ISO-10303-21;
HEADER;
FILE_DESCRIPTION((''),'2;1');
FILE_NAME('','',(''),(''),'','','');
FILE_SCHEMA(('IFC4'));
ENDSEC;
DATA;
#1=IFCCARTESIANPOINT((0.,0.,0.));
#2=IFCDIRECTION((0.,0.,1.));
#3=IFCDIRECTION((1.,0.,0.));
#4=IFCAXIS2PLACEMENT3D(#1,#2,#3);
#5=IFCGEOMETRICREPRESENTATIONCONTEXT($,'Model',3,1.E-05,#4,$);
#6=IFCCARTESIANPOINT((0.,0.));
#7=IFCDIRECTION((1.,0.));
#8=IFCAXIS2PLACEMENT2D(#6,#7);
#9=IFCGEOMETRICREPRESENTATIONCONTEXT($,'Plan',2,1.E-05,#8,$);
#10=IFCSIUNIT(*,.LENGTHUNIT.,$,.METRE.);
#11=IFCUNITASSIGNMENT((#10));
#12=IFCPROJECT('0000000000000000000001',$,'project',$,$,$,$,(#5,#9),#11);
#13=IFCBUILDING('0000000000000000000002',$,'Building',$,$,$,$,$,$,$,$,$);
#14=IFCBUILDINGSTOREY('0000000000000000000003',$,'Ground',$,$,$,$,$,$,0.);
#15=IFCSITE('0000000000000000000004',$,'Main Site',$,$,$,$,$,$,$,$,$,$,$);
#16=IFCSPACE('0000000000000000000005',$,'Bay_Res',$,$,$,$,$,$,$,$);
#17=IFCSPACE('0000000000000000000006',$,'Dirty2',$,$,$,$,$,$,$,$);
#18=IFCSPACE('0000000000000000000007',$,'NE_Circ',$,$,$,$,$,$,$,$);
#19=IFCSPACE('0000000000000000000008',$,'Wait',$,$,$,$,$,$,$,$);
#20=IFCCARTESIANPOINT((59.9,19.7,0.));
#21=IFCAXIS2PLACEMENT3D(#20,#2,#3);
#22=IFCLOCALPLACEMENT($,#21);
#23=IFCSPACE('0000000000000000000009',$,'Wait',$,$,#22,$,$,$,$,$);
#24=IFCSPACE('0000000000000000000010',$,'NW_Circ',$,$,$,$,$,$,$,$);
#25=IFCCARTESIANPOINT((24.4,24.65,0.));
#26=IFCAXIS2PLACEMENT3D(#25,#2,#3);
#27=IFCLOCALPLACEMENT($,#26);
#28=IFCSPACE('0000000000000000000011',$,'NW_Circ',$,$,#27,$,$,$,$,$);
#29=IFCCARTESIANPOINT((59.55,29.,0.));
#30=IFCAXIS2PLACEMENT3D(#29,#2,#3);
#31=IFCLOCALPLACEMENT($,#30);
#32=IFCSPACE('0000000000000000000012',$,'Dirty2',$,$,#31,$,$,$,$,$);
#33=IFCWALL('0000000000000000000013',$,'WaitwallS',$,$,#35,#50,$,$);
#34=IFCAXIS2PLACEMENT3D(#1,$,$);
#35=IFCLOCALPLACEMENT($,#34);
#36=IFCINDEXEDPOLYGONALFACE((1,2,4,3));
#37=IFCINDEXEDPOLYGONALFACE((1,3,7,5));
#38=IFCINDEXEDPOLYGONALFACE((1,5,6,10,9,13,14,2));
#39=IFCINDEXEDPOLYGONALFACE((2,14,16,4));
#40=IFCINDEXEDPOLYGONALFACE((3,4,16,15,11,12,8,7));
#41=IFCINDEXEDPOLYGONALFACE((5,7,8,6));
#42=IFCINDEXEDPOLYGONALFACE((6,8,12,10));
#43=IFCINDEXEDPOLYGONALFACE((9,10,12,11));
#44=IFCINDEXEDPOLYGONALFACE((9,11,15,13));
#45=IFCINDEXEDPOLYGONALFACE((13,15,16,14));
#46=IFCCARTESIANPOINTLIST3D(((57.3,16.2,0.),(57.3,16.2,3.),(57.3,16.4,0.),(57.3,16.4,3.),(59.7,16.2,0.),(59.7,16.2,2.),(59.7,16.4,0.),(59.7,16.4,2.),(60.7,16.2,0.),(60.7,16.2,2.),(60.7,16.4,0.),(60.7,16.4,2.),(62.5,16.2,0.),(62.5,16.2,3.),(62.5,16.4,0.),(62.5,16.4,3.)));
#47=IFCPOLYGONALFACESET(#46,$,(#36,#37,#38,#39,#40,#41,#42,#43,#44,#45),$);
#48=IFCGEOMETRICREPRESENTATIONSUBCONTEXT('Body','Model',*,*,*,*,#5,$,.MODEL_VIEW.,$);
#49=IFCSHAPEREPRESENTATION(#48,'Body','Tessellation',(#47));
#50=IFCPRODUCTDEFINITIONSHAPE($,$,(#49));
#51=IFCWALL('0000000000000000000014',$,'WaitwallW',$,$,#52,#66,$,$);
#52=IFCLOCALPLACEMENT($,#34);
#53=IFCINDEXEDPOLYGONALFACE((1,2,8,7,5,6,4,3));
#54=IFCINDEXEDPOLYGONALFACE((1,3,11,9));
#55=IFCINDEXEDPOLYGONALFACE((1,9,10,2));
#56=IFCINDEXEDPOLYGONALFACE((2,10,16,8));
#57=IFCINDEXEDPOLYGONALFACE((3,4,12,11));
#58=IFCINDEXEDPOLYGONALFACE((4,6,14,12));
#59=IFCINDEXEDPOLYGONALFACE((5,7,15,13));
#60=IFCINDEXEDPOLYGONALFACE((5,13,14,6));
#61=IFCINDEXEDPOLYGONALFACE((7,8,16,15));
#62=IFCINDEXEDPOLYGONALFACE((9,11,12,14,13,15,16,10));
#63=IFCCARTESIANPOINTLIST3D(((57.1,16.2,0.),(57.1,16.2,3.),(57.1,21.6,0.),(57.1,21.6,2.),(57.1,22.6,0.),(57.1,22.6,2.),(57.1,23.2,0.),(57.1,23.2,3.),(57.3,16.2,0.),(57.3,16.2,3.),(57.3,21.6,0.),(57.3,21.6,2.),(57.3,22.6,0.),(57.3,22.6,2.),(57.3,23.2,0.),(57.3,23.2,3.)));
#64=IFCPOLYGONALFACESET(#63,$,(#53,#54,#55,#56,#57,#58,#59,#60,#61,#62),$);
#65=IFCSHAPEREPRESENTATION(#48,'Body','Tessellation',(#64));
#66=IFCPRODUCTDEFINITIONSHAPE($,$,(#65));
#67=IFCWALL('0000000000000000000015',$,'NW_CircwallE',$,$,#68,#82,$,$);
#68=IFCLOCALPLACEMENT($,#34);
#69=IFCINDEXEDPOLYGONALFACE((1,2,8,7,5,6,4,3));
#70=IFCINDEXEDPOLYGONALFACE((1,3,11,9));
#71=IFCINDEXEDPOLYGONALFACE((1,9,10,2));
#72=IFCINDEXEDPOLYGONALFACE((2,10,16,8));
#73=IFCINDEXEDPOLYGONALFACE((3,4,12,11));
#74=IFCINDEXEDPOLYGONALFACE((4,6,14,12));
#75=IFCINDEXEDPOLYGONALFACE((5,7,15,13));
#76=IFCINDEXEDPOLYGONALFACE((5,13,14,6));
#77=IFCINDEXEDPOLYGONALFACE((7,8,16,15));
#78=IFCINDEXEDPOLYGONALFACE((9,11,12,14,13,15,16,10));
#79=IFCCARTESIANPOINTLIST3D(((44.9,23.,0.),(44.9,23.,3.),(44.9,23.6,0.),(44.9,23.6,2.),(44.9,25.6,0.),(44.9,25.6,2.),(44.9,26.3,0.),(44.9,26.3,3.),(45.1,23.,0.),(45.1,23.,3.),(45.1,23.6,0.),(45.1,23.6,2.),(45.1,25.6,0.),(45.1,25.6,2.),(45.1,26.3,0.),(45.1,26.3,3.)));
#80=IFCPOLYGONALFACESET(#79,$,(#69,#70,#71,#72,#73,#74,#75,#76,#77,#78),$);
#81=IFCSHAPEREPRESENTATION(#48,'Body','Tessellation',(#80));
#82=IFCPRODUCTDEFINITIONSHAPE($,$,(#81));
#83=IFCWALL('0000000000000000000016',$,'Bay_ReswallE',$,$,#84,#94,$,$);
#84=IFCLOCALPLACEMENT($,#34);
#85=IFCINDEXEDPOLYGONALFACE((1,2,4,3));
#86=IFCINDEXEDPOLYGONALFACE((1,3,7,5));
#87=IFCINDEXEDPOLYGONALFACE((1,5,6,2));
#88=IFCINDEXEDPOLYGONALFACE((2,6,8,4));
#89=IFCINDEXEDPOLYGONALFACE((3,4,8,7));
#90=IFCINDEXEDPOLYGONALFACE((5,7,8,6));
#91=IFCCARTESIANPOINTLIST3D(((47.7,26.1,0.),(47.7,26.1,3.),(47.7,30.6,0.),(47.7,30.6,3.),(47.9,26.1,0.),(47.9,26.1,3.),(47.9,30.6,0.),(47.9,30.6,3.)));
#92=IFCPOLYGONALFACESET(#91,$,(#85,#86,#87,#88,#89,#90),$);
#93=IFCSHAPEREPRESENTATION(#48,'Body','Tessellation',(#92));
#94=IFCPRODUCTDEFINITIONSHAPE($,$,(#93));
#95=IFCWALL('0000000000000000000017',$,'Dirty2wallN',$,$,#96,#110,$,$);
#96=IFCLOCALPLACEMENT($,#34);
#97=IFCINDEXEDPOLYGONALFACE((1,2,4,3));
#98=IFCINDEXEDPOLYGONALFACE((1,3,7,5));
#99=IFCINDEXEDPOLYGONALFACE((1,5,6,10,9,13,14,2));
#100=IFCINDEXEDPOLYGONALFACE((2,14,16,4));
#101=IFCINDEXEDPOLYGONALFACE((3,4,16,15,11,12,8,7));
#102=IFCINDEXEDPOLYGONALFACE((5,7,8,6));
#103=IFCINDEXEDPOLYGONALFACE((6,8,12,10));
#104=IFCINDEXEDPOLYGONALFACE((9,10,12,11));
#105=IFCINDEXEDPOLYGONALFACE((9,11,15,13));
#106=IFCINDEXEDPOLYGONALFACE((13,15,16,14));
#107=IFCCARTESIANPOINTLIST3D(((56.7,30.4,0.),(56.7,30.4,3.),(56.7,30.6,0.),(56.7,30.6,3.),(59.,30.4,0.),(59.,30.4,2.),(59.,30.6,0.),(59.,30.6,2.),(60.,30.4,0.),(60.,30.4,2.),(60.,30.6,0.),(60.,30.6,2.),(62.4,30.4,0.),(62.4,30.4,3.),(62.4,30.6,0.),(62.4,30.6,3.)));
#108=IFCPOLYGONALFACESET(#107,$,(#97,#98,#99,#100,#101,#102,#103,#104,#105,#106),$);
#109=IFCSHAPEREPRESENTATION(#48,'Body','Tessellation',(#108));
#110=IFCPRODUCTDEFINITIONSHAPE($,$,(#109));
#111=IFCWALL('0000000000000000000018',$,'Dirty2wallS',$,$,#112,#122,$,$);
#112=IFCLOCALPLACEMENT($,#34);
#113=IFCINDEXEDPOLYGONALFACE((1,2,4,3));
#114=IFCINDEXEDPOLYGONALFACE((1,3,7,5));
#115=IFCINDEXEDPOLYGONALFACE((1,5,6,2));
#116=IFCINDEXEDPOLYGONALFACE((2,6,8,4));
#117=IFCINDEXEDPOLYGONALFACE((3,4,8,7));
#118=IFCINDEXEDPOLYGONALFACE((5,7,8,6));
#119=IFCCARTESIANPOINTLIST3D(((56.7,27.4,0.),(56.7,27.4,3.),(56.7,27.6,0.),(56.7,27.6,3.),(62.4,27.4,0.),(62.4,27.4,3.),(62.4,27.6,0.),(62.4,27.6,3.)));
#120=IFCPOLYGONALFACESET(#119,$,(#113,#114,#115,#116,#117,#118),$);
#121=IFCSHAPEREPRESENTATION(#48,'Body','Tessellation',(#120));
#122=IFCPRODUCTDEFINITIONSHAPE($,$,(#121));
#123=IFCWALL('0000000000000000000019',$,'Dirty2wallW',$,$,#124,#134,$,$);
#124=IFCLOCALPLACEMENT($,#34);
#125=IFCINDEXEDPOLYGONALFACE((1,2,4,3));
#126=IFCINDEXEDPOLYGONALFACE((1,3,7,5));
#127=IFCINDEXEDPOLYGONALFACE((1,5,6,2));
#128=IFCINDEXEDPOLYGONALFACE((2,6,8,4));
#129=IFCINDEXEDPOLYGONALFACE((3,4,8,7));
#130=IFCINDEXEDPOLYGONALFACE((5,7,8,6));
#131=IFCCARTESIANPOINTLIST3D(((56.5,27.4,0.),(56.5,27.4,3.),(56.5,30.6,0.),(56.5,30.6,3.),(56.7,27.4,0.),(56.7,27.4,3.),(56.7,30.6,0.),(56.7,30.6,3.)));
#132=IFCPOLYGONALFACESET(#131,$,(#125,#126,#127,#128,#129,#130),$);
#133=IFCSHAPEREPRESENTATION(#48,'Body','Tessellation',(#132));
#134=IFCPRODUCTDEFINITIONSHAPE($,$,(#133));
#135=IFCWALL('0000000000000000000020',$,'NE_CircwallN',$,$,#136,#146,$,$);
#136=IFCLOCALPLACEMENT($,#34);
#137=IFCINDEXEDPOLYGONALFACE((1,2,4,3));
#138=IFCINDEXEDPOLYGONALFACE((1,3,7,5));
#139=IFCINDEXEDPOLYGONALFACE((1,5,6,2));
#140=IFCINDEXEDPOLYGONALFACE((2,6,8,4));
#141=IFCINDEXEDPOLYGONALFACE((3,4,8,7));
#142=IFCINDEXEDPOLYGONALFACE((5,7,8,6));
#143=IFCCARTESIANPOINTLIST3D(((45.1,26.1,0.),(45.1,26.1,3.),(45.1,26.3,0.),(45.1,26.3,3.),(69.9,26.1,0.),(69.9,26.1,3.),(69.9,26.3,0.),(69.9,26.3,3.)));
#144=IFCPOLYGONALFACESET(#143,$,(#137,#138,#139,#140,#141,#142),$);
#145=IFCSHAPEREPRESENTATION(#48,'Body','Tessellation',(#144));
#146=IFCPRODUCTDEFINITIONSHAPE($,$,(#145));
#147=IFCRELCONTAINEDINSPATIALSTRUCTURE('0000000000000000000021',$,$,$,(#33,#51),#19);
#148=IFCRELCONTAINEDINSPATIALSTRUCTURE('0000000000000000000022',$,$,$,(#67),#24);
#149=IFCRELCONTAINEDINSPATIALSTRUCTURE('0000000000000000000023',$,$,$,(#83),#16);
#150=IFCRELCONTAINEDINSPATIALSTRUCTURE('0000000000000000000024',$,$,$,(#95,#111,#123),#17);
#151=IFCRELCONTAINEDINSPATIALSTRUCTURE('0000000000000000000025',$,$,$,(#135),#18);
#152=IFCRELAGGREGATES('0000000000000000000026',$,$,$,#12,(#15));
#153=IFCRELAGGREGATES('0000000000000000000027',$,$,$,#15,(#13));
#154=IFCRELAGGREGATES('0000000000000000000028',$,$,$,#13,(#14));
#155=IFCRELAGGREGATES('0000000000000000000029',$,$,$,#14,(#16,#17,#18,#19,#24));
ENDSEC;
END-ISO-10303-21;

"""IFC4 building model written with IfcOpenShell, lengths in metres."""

from ifc_helpers import new_model, si_unit, frame, origin_with_axes, origin_2d_with_axis, place, context, subcontext, project, spatial, indexed_curve, outline, extrude, element, save


model = new_model("IFC4")

# Units and contexts
model_context = context("Model", 3, precision=1e-05, world=origin_with_axes())
plan_context = context("Plan", 2, precision=1e-05, world=origin_2d_with_axis())
body_context = subcontext(model_context, "Body", "Model", "MODEL_VIEW")
ifc_project = project(units=[si_unit("LENGTHUNIT", "METRE")], contexts=[model_context, plan_context])

# Site, building, storey
site = spatial("IfcSite", under=ifc_project, Name="Main Site")
building = spatial("IfcBuilding", under=site, Name="Building")
storey = spatial("IfcBuildingStorey", under=building, Name="Ground", Elevation=0.0)

# Shared definitions
space_1 = spatial("IfcSpace", under=storey, Name="Bay_Res")

# Shared definitions
space_2 = spatial("IfcSpace", under=storey, Name="Dirty2")

# Shared definitions
space_3 = spatial("IfcSpace", under=storey, Name="NE_Circ")

# Shared definitions
space_4 = spatial("IfcSpace", under=storey, Name="Wait")

# Shared definitions
space_5_placement = place(None, frame((59.9, 19.7, 0.0), z_axis=(0.0, 0.0, 1.0), x_axis=(1.0, 0.0, 0.0)))
space_5 = spatial("IfcSpace", at=space_5_placement, Name="Wait")

# Walls, openings
wall_1_placement = place(None, frame((57.3, 16.2, 0.0), z_axis=(0.0, 0.0, 1.0), x_axis=(1.0, 0.0, 0.0)))
wall_1 = element("IfcWall", 1, at=wall_1_placement, inside=space_4, Name="WaitwallS", context=body_context, shape_type="SweptSolid", body=[
    extrude(outline(indexed_curve([(0.0, 0.0), (0.0, 0.2), (5.2, 0.2), (5.2, 0.0), (0.0, 0.0)], self_intersect=False)), origin_with_axes(), (0.0, 0.0, 1.0), 3.0),
])
opening_1_placement = place(wall_1_placement, frame((2.4, 0.0, 0.0), z_axis=(0.0, 0.0, 1.0), x_axis=(1.0, 0.0, 0.0)))
element("IfcOpeningElement", 2, at=opening_1_placement, inside=space_5, cuts=wall_1, context=body_context, shape_type="SweptSolid", body=[
    extrude(outline(indexed_curve([(0.0, 0.0), (0.0, 0.4), (1.0, 0.4), (1.0, 0.0), (0.0, 0.0)], self_intersect=False)), origin_with_axes(), (0.0, 0.0, 1.0), 2.0),
])
wall_2_placement = place(None, frame((57.3, 16.2, 0.0), z_axis=(0.0, 0.0, 1.0), x_axis=(0.0, 1.0, 0.0)))
wall_2 = element("IfcWall", 3, at=wall_2_placement, inside=space_4, Name="WaitwallW", context=body_context, shape_type="SweptSolid", body=[
    extrude(outline(indexed_curve([(0.0, 0.0), (0.0, 0.2), (7.0, 0.2), (7.0, 0.0), (0.0, 0.0)], self_intersect=False)), origin_with_axes(), (0.0, 0.0, 1.0), 3.0),
])
opening_2_placement = place(wall_2_placement, frame((5.4, 0.0, 0.0), z_axis=(0.0, 0.0, 1.0), x_axis=(1.0, 0.0, 0.0)))
element("IfcOpeningElement", 4, at=opening_2_placement, inside=space_5, cuts=wall_2, context=body_context, shape_type="SweptSolid", body=[
    extrude(outline(indexed_curve([(0.0, 0.0), (0.0, 0.4), (1.0, 0.4), (1.0, 0.0), (0.0, 0.0)], self_intersect=False)), origin_with_axes(), (0.0, 0.0, 1.0), 2.0),
])

# Shared definitions
space_6 = spatial("IfcSpace", under=storey, Name="NW_Circ")

# Wall
wall_3_placement = place(None, frame((45.1, 23.0, 0.0), z_axis=(0.0, 0.0, 1.0), x_axis=(0.0, 1.0, 0.0)))
wall_3 = element("IfcWall", 5, at=wall_3_placement, inside=space_6, Name="NW_CircwallE", context=body_context, shape_type="SweptSolid", body=[
    extrude(outline(indexed_curve([(0.0, 0.0), (0.0, 0.2), (3.3, 0.2), (3.3, 0.0), (0.0, 0.0)], self_intersect=False)), origin_with_axes(), (0.0, 0.0, 1.0), 3.0),
])

# Shared definitions
space_7_placement = place(None, frame((24.4, 24.65, 0.0), z_axis=(0.0, 0.0, 1.0), x_axis=(1.0, 0.0, 0.0)))
space_7 = spatial("IfcSpace", at=space_7_placement, Name="NW_Circ")

# Opening
opening_3_placement = place(wall_3_placement, frame((0.6, 0.0, 0.0), z_axis=(0.0, 0.0, 1.0), x_axis=(1.0, 0.0, 0.0)))
element("IfcOpeningElement", 6, at=opening_3_placement, inside=space_7, cuts=wall_3, context=body_context, shape_type="SweptSolid", body=[
    extrude(outline(indexed_curve([(0.0, 0.0), (0.0, 0.4), (2.0, 0.4), (2.0, 0.0), (0.0, 0.0)], self_intersect=False)), origin_with_axes(), (0.0, 0.0, 1.0), 2.0),
])

# Walls
wall_4_placement = place(None, frame((47.9, 26.1, 0.0), z_axis=(0.0, 0.0, 1.0), x_axis=(0.0, 1.0, 0.0)))
element("IfcWall", 7, at=wall_4_placement, inside=space_1, Name="Bay_ReswallE", context=body_context, shape_type="SweptSolid", body=[
    extrude(outline(indexed_curve([(0.0, 0.0), (0.0, 0.2), (4.5, 0.2), (4.5, 0.0), (0.0, 0.0)], self_intersect=False)), origin_with_axes(), (0.0, 0.0, 1.0), 3.0),
])
wall_5_placement = place(None, frame((56.7, 30.4, 0.0), z_axis=(0.0, 0.0, 1.0), x_axis=(1.0, 0.0, 0.0)))
wall_5 = element("IfcWall", 8, at=wall_5_placement, inside=space_2, Name="Dirty2wallN", context=body_context, shape_type="SweptSolid", body=[
    extrude(outline(indexed_curve([(0.0, 0.0), (0.0, 0.2), (5.7, 0.2), (5.7, 0.0), (0.0, 0.0)], self_intersect=False)), origin_with_axes(), (0.0, 0.0, 1.0), 3.0),
])

# Shared definitions
space_8_placement = place(None, frame((59.55, 29.0, 0.0), z_axis=(0.0, 0.0, 1.0), x_axis=(1.0, 0.0, 0.0)))
space_8 = spatial("IfcSpace", at=space_8_placement, Name="Dirty2")

# Opening
opening_4_placement = place(wall_5_placement, frame((2.3, 0.0, 0.0), z_axis=(0.0, 0.0, 1.0), x_axis=(1.0, 0.0, 0.0)))
element("IfcOpeningElement", 9, at=opening_4_placement, inside=space_8, cuts=wall_5, context=body_context, shape_type="SweptSolid", body=[
    extrude(outline(indexed_curve([(0.0, 0.0), (0.0, 0.4), (1.0, 0.4), (1.0, 0.0), (0.0, 0.0)], self_intersect=False)), origin_with_axes(), (0.0, 0.0, 1.0), 2.0),
])

# Walls
wall_6_placement = place(None, frame((56.7, 27.4, 0.0), z_axis=(0.0, 0.0, 1.0), x_axis=(1.0, 0.0, 0.0)))
element("IfcWall", 10, at=wall_6_placement, inside=space_2, Name="Dirty2wallS", context=body_context, shape_type="SweptSolid", body=[
    extrude(outline(indexed_curve([(0.0, 0.0), (0.0, 0.2), (5.7, 0.2), (5.7, 0.0), (0.0, 0.0)], self_intersect=False)), origin_with_axes(), (0.0, 0.0, 1.0), 3.0),
])
wall_7_placement = place(None, frame((56.7, 27.4, 0.0), z_axis=(0.0, 0.0, 1.0), x_axis=(0.0, 1.0, 0.0)))
element("IfcWall", 11, at=wall_7_placement, inside=space_2, Name="Dirty2wallW", context=body_context, shape_type="SweptSolid", body=[
    extrude(outline(indexed_curve([(0.0, 0.0), (0.0, 0.2), (3.2, 0.2), (3.2, 0.0), (0.0, 0.0)], self_intersect=False)), origin_with_axes(), (0.0, 0.0, 1.0), 3.0),
])
wall_8_placement = place(None, frame((45.1, 26.1, 0.0), z_axis=(0.0, 0.0, 1.0), x_axis=(1.0, 0.0, 0.0)))
element("IfcWall", 12, at=wall_8_placement, inside=space_3, Name="NE_CircwallN", context=body_context, shape_type="SweptSolid", body=[
    extrude(outline(indexed_curve([(0.0, 0.0), (0.0, 0.2), (24.8, 0.2), (24.8, 0.0), (0.0, 0.0)], self_intersect=False)), origin_with_axes(), (0.0, 0.0, 1.0), 3.0),
])

save(model, "model.ifc")
